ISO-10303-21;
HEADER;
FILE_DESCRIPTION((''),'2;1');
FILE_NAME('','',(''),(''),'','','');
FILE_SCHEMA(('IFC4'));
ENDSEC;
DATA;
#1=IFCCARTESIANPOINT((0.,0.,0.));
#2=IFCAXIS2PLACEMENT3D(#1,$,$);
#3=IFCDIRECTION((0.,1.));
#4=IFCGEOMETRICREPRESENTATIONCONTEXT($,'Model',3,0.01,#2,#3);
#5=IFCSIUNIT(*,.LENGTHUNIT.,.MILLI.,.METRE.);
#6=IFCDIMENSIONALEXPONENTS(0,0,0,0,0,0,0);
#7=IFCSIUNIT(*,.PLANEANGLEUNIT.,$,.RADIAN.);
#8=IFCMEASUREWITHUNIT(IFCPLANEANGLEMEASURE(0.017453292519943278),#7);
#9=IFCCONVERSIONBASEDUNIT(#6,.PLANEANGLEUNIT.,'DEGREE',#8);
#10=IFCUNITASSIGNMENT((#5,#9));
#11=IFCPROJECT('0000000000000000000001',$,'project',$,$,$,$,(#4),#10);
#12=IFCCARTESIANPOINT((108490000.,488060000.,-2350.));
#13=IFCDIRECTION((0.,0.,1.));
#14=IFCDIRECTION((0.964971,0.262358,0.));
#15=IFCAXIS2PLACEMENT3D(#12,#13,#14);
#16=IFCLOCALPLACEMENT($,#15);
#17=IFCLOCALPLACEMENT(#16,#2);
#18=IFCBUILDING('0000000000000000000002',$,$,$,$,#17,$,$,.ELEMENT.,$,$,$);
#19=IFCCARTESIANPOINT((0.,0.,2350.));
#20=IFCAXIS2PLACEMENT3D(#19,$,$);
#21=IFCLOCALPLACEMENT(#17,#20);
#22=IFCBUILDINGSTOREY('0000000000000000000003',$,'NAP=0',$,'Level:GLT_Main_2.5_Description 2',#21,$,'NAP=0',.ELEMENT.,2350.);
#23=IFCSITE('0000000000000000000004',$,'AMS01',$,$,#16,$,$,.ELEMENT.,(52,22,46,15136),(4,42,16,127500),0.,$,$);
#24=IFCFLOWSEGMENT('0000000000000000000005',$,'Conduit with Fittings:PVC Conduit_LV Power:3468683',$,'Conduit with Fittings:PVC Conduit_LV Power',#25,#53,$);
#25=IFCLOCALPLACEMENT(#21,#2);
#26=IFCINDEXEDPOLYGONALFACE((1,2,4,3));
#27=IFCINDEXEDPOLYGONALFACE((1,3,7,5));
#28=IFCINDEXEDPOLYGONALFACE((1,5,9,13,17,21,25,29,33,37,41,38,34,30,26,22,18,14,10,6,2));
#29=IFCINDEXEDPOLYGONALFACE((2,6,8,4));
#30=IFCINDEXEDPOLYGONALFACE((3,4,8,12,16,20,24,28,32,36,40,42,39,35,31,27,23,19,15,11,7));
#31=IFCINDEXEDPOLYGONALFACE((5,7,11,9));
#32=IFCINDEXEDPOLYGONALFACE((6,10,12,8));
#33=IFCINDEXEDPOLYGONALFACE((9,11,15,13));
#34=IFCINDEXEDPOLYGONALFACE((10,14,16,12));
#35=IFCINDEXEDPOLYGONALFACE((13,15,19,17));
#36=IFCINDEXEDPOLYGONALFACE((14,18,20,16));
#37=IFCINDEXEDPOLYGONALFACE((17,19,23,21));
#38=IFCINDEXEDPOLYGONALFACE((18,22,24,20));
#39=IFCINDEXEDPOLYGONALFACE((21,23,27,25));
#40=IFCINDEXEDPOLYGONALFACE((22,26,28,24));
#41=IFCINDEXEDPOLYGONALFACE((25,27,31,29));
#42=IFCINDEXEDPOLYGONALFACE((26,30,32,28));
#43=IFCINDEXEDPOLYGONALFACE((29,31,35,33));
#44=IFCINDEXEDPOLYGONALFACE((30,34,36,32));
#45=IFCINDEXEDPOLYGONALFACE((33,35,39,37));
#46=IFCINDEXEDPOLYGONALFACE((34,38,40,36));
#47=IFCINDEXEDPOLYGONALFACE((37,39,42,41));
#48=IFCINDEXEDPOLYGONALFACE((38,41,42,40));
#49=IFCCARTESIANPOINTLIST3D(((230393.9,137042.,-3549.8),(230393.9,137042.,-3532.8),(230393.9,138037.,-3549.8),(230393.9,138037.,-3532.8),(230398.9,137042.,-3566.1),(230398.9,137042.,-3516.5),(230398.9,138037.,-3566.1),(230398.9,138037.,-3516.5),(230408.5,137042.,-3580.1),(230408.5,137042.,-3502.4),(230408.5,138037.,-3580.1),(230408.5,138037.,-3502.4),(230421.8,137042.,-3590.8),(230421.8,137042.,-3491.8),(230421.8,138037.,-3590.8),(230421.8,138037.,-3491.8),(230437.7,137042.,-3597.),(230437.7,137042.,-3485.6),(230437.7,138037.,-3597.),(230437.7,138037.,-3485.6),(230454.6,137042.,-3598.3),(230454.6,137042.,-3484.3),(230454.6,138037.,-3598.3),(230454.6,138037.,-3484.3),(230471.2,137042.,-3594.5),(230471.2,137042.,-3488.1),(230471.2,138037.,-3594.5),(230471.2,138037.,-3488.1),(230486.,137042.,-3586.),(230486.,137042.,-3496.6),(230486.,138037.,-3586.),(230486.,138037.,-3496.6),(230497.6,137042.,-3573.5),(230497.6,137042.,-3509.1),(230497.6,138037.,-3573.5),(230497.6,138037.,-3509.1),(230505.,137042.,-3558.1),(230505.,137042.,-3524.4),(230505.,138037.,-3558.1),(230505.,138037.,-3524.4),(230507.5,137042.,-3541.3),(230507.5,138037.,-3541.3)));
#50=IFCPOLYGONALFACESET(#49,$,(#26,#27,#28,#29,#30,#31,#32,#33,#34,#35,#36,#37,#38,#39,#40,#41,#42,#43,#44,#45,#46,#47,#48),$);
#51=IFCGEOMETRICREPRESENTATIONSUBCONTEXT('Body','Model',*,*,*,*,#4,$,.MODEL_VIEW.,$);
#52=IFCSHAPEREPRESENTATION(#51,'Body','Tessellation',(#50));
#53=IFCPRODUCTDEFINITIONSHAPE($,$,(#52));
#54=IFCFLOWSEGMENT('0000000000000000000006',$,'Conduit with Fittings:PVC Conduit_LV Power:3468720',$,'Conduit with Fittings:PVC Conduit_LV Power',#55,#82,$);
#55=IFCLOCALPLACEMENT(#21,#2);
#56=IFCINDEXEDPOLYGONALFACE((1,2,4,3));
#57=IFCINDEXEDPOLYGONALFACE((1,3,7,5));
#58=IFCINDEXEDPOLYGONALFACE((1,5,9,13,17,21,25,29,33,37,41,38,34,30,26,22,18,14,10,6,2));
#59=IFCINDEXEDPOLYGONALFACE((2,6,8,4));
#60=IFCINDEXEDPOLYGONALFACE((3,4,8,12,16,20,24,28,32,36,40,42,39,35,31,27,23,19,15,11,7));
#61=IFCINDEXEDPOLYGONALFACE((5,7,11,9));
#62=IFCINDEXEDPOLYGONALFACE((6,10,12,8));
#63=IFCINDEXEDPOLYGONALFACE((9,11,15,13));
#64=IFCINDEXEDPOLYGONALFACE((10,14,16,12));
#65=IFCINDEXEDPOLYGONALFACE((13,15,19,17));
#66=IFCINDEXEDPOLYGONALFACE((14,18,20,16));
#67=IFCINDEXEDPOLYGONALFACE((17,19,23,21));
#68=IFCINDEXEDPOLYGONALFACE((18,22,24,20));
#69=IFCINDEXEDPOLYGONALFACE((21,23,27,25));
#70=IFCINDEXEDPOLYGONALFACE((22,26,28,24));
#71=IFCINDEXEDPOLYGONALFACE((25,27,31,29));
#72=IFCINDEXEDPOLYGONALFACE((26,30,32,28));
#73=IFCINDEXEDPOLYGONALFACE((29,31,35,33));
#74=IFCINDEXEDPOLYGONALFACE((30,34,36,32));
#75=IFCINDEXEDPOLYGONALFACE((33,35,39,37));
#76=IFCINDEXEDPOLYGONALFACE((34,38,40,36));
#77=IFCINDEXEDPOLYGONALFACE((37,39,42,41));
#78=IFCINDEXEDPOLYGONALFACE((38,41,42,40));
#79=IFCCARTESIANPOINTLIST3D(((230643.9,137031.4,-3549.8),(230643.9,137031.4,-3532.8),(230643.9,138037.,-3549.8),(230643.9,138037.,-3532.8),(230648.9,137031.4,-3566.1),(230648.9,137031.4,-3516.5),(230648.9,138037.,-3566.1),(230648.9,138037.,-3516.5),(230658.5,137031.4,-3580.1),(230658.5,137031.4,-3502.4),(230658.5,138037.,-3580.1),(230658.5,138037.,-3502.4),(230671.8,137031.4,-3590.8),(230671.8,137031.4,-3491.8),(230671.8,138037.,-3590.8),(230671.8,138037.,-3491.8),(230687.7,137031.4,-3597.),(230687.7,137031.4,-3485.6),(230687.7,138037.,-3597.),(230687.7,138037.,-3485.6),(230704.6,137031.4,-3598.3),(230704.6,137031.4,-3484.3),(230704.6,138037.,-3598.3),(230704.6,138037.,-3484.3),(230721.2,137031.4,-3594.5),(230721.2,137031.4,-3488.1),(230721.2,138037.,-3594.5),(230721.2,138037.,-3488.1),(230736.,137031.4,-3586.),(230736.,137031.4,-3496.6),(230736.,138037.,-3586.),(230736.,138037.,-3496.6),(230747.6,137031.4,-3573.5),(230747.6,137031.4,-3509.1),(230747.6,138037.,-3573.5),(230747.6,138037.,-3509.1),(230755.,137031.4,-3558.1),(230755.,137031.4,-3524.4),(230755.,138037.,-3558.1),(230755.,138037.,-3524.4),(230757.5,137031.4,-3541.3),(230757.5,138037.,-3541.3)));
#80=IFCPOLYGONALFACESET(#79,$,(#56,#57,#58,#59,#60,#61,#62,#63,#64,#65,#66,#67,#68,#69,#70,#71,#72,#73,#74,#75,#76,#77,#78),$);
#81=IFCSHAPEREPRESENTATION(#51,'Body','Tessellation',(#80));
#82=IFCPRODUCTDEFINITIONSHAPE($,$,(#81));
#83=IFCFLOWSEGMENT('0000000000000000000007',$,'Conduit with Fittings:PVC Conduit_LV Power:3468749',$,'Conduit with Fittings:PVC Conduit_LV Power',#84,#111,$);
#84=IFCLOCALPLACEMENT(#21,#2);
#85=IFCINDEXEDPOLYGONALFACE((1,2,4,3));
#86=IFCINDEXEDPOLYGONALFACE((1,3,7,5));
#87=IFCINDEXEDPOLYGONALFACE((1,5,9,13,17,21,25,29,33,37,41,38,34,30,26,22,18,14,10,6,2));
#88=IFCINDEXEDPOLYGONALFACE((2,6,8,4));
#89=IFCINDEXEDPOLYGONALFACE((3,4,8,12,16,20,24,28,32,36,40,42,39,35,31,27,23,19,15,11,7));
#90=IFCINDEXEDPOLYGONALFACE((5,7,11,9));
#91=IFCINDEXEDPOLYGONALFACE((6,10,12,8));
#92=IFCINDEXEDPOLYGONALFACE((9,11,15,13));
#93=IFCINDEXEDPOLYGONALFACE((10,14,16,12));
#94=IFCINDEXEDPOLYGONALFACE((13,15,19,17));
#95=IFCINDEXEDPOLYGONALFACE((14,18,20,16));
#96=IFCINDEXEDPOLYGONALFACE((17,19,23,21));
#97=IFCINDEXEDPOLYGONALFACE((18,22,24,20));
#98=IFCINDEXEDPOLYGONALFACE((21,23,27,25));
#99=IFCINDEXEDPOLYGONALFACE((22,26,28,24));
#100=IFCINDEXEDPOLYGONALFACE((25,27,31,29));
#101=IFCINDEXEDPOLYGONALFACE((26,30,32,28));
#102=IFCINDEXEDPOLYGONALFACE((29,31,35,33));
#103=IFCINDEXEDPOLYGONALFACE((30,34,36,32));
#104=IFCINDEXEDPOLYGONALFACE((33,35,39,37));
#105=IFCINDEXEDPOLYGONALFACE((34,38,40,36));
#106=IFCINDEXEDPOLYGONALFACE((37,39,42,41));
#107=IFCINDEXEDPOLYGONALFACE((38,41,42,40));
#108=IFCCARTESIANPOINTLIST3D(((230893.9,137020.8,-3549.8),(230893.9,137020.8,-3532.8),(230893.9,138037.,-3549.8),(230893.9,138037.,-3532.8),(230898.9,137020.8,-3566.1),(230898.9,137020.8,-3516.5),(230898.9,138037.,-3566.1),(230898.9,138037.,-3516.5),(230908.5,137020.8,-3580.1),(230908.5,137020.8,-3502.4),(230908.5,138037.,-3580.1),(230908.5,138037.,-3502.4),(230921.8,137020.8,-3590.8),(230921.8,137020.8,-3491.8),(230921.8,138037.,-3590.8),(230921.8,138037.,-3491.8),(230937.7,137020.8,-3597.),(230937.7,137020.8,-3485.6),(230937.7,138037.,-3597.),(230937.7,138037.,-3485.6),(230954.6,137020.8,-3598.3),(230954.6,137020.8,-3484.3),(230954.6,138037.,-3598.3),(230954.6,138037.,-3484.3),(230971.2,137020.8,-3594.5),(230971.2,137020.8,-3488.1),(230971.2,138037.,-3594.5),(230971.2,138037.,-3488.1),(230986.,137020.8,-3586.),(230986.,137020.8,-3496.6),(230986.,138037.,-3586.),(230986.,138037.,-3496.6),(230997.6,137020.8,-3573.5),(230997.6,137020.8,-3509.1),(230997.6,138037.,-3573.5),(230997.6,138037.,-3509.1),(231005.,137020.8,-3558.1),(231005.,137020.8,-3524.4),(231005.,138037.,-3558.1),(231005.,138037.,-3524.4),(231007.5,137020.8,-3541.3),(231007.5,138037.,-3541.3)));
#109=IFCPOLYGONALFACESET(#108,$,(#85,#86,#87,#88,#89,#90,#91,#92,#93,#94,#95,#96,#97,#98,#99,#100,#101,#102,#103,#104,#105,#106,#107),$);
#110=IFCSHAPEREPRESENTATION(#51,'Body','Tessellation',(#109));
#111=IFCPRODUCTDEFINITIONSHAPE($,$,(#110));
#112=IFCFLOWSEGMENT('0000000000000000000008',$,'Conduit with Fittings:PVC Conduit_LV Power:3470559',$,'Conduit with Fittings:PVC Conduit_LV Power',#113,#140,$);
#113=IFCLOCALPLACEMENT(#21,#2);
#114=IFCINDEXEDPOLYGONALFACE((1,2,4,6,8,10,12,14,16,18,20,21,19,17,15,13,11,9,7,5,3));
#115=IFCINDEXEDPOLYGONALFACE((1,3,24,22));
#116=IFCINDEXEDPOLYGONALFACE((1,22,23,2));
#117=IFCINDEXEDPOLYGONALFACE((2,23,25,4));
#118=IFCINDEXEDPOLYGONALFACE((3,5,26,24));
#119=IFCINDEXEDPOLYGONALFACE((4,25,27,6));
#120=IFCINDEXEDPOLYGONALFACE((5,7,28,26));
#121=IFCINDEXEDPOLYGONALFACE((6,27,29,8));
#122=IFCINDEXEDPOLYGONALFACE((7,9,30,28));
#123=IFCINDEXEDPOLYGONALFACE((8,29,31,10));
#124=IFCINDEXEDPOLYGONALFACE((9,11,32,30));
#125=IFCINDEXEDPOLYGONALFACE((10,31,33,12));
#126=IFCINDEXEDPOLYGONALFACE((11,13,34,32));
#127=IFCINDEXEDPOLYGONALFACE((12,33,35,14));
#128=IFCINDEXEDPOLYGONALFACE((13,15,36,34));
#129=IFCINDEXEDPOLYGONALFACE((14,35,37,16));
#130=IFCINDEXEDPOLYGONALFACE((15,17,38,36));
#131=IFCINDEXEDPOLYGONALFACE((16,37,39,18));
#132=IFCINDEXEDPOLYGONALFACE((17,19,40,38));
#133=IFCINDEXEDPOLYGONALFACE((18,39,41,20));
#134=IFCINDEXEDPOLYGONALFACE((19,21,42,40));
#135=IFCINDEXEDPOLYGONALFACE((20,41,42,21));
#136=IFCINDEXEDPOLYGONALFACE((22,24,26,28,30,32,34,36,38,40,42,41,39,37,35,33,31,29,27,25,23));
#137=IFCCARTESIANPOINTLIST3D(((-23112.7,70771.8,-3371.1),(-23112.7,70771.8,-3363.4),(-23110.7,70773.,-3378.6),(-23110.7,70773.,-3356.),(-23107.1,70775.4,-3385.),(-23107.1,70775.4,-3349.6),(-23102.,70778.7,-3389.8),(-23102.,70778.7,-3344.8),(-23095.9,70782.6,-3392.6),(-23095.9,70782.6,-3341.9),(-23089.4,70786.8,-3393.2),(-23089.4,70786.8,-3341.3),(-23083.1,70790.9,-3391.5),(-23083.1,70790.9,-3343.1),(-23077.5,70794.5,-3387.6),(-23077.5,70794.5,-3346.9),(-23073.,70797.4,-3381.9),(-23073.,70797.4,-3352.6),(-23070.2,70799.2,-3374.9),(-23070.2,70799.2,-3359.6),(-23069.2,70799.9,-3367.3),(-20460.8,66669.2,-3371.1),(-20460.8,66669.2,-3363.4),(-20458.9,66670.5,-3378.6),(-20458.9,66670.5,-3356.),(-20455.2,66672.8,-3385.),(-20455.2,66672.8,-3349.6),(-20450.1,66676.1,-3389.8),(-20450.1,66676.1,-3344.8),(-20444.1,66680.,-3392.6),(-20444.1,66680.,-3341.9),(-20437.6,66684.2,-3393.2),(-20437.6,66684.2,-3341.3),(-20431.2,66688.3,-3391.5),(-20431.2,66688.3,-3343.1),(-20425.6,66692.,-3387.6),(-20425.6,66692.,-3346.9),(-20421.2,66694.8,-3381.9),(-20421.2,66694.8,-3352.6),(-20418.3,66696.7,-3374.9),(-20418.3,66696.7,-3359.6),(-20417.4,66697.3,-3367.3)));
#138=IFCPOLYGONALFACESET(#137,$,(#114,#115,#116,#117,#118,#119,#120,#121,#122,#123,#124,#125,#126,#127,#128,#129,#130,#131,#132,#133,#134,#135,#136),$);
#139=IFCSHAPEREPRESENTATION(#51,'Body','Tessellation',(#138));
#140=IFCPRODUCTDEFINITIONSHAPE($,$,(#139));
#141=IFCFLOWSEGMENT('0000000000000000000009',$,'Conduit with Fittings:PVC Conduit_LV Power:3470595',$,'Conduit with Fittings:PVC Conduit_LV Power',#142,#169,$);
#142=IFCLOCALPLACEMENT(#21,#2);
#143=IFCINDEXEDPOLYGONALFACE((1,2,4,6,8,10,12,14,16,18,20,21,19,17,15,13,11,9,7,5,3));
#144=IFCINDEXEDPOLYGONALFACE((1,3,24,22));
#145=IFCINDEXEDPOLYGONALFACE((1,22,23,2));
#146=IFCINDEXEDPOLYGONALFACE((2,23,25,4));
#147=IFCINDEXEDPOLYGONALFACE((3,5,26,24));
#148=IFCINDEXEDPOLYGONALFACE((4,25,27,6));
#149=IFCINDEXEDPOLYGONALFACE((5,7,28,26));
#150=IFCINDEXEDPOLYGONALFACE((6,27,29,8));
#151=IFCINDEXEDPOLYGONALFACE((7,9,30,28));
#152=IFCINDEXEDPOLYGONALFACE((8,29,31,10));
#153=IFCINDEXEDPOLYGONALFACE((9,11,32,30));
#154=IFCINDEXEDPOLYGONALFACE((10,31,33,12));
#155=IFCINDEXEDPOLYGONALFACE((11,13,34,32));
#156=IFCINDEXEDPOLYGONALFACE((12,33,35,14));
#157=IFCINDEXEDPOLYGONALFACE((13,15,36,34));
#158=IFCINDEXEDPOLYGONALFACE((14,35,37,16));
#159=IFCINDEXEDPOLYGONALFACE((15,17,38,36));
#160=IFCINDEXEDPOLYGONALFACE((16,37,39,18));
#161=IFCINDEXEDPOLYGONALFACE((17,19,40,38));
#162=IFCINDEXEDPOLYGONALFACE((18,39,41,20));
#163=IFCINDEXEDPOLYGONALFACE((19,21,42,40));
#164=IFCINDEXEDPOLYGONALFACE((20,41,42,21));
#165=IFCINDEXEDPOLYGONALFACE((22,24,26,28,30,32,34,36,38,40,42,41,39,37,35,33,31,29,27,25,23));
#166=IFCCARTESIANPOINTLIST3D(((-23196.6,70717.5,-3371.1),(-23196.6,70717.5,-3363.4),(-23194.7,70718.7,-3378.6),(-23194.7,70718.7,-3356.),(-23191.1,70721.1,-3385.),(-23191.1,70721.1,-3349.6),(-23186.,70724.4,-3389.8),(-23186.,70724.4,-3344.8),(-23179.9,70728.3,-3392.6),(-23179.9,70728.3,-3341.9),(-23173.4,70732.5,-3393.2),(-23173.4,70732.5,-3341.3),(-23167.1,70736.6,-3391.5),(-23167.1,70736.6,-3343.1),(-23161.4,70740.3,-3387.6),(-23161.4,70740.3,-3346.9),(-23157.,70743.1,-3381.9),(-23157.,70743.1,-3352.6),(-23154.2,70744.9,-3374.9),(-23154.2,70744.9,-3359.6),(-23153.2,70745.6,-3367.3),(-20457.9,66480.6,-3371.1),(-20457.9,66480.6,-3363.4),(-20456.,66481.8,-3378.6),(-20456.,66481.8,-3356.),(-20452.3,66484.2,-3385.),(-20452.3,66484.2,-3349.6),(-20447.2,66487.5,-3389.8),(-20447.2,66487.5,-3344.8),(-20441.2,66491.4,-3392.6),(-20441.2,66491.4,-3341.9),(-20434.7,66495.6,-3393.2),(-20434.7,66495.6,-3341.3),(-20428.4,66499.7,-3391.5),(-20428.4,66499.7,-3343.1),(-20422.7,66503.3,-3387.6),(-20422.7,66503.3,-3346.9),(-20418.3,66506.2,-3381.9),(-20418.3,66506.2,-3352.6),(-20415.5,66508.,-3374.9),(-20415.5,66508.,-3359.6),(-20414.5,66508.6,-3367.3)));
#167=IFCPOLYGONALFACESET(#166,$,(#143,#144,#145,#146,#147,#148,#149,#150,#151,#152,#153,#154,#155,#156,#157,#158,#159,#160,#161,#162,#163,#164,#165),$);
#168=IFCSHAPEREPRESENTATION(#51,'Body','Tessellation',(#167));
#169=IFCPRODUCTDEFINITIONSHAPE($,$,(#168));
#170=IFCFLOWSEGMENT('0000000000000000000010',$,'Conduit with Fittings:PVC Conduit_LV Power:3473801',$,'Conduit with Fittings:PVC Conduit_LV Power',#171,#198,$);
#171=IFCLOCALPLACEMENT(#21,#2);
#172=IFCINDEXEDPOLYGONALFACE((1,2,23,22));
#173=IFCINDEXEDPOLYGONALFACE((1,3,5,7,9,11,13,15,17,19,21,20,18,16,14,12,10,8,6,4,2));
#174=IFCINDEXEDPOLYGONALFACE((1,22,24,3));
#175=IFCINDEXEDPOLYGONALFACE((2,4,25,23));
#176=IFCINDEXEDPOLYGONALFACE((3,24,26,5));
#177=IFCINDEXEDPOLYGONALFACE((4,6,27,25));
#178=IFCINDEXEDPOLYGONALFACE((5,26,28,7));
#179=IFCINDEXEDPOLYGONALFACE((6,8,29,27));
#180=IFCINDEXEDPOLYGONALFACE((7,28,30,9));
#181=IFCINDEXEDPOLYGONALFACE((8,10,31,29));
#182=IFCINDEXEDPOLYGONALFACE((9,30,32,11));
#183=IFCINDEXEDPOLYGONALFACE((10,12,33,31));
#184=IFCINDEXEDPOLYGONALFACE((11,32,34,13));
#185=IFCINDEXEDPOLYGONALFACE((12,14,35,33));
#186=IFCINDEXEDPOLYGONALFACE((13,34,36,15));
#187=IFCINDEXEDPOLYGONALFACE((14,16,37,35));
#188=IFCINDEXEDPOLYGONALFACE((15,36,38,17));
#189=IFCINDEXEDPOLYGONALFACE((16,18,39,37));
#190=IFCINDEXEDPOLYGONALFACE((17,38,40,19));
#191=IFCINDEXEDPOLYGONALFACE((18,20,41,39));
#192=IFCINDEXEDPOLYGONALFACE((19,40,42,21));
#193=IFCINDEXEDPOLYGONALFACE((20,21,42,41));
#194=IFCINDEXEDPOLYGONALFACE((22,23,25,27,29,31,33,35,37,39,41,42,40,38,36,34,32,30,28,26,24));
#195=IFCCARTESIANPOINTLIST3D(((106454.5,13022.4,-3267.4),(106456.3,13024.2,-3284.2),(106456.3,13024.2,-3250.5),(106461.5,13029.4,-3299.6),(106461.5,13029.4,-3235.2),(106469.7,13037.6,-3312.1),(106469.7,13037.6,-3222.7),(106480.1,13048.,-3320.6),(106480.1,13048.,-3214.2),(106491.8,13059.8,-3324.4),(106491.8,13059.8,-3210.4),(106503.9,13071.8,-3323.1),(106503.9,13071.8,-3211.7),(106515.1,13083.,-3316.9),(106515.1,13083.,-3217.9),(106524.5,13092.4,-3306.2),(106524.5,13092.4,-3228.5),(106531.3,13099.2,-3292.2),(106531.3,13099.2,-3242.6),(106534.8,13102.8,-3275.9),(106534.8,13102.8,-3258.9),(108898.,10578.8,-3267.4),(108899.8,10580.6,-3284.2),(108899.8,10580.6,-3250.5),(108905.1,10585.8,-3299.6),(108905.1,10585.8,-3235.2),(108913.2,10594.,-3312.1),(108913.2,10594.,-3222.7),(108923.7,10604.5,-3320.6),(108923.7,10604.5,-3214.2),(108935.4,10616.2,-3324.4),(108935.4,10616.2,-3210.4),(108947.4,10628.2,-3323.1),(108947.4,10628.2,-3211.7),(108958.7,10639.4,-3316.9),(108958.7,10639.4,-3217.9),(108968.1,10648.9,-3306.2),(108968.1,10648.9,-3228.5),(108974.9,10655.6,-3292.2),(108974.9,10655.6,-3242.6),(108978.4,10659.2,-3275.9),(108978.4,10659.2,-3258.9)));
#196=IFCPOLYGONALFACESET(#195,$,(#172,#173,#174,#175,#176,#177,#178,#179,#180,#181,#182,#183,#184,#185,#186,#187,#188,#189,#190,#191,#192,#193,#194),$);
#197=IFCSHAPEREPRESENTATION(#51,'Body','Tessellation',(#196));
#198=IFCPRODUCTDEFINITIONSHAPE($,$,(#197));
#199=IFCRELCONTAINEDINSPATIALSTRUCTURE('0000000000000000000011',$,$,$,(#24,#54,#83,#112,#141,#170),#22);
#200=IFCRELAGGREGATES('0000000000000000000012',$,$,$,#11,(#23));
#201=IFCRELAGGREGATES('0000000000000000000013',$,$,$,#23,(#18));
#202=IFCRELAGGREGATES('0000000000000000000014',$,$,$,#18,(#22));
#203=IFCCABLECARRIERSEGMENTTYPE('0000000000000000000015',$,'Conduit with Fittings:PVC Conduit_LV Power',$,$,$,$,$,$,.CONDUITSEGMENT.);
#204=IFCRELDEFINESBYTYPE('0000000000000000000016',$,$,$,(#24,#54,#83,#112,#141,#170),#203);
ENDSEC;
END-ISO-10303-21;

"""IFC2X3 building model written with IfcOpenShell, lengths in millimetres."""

from ifc_helpers import new_model, entity, si_unit, converted_unit, direction, frame, frame_2d, origin, origin_2d_with_axis, place, context, subcontext, project, spatial, circle, extrude, type_object, element, save


model = new_model("IFC2X3")

# Units and contexts
model_context = context("Model", 3, precision=0.01, world=origin(), true_north=direction((0.0, 1.0)))
body_context = subcontext(model_context, "Body", "Model", "MODEL_VIEW")
ifc_project = project(units=[si_unit("LENGTHUNIT", "METRE", prefix="MILLI"), converted_unit("PLANEANGLEUNIT", "DEGREE", entity("IfcPlaneAngleMeasure", 0.017453292519943278), si_unit("PLANEANGLEUNIT", "RADIAN"), dimensions=[0, 0, 0, 0, 0, 0, 0])], contexts=[model_context])

# Site, building, storey
site_placement = place(None, frame((108490000.0, 488060000.0, -2350.0), z_axis=(0.0, 0.0, 1.0), x_axis=(0.964971, 0.262358, 0.0)))
site = spatial("IfcSite", under=ifc_project, at=site_placement, Name="AMS01", CompositionType="ELEMENT", RefLatitude=(52, 22, 46, 15136), RefLongitude=(4, 42, 16, 127500), RefElevation=0.0)
building_placement = place(site_placement, origin())
building = spatial("IfcBuilding", under=site, at=building_placement, CompositionType="ELEMENT")
storey_placement = place(building_placement, frame((0.0, 0.0, 2350.0)))
storey = spatial("IfcBuildingStorey", under=building, at=storey_placement, Name="NAP=0", ObjectType="Level:GLT_Main_2.5_Description 2", LongName="NAP=0", CompositionType="ELEMENT", Elevation=2350.0)

# Flow segments
cable_carrier_segment_type = type_object("IfcCableCarrierSegmentType", Name="Conduit with Fittings:PVC Conduit_LV Power", PredefinedType="CONDUITSEGMENT")
flow_segment_1_placement = place(storey_placement, origin())
element("IfcFlowSegment", 1, at=flow_segment_1_placement, inside=storey, type_object=cable_carrier_segment_type, Name="Conduit with Fittings:PVC Conduit_LV Power:3468683", ObjectType="Conduit with Fittings:PVC Conduit_LV Power", context=body_context, shape_type="SweptSolid", body=[
    extrude(circle(Radius=57.2, at=frame_2d((0.0, 0.0), x_axis=(1.0, 0.0))), frame((230450.4, 137042.0, -3541.3), z_axis=(0.0, 1.0, 0.0), x_axis=(1.0, 0.0, 0.0)), (0.0, 0.0, 1.0), 995.0),
])
flow_segment_2_placement = place(storey_placement, origin())
element("IfcFlowSegment", 2, at=flow_segment_2_placement, inside=storey, type_object=cable_carrier_segment_type, Name="Conduit with Fittings:PVC Conduit_LV Power:3468720", ObjectType="Conduit with Fittings:PVC Conduit_LV Power", context=body_context, shape_type="SweptSolid", body=[
    extrude(circle(Radius=57.2, at=origin_2d_with_axis()), frame((230700.4, 137031.4, -3541.3), z_axis=(0.0, 1.0, 0.0), x_axis=(1.0, 0.0, 0.0)), (0.0, 0.0, 1.0), 1005.6),
])
flow_segment_3_placement = place(storey_placement, origin())
element("IfcFlowSegment", 3, at=flow_segment_3_placement, inside=storey, type_object=cable_carrier_segment_type, Name="Conduit with Fittings:PVC Conduit_LV Power:3468749", ObjectType="Conduit with Fittings:PVC Conduit_LV Power", context=body_context, shape_type="SweptSolid", body=[
    extrude(circle(Radius=57.2, at=frame_2d((0.0, 0.0), x_axis=(1.0, 0.0))), frame((230950.4, 137020.8, -3541.3), z_axis=(0.0, 1.0, 0.0), x_axis=(1.0, 0.0, 0.0)), (0.0, 0.0, 1.0), 1016.2),
])
flow_segment_4_placement = place(storey_placement, origin())
element("IfcFlowSegment", 4, at=flow_segment_4_placement, inside=storey, type_object=cable_carrier_segment_type, Name="Conduit with Fittings:PVC Conduit_LV Power:3470559", ObjectType="Conduit with Fittings:PVC Conduit_LV Power", context=body_context, shape_type="SweptSolid", body=[
    extrude(circle(Radius=26.0, at=origin_2d_with_axis()), frame((-23091.1, 70785.7, -3367.3), z_axis=(0.542856, -0.839826, 0.0), x_axis=(0.839826, 0.542856, 0.0)), (0.0, 0.0, 1.0), 4885.0),
])
flow_segment_5_placement = place(storey_placement, origin())
element("IfcFlowSegment", 5, at=flow_segment_5_placement, inside=storey, type_object=cable_carrier_segment_type, Name="Conduit with Fittings:PVC Conduit_LV Power:3470595", ObjectType="Conduit with Fittings:PVC Conduit_LV Power", context=body_context, shape_type="SweptSolid", body=[
    extrude(circle(Radius=26.0, at=frame_2d((0.0, 0.0), x_axis=(1.0, 0.0))), frame((-23175.1, 70731.5, -3367.3), z_axis=(0.542856, -0.839826, 0.0), x_axis=(0.839826, 0.542856, 0.0)), (0.0, 0.0, 1.0), 5045.0),
])
flow_segment_6_placement = place(storey_placement, origin())
element("IfcFlowSegment", 6, at=flow_segment_6_placement, inside=storey, type_object=cable_carrier_segment_type, Name="Conduit with Fittings:PVC Conduit_LV Power:3473801", ObjectType="Conduit with Fittings:PVC Conduit_LV Power", context=body_context, shape_type="SweptSolid", body=[
    extrude(circle(Radius=57.2, at=frame_2d((0.0, 0.0), x_axis=(1.0, 0.0))), frame((106494.9, 13062.8, -3267.4), z_axis=(0.707107, -0.707107, 0.0), x_axis=(-0.707107, -0.707107, 0.0)), (0.0, 0.0, 1.0), 3455.7),
])

save(model, "model.ifc")
